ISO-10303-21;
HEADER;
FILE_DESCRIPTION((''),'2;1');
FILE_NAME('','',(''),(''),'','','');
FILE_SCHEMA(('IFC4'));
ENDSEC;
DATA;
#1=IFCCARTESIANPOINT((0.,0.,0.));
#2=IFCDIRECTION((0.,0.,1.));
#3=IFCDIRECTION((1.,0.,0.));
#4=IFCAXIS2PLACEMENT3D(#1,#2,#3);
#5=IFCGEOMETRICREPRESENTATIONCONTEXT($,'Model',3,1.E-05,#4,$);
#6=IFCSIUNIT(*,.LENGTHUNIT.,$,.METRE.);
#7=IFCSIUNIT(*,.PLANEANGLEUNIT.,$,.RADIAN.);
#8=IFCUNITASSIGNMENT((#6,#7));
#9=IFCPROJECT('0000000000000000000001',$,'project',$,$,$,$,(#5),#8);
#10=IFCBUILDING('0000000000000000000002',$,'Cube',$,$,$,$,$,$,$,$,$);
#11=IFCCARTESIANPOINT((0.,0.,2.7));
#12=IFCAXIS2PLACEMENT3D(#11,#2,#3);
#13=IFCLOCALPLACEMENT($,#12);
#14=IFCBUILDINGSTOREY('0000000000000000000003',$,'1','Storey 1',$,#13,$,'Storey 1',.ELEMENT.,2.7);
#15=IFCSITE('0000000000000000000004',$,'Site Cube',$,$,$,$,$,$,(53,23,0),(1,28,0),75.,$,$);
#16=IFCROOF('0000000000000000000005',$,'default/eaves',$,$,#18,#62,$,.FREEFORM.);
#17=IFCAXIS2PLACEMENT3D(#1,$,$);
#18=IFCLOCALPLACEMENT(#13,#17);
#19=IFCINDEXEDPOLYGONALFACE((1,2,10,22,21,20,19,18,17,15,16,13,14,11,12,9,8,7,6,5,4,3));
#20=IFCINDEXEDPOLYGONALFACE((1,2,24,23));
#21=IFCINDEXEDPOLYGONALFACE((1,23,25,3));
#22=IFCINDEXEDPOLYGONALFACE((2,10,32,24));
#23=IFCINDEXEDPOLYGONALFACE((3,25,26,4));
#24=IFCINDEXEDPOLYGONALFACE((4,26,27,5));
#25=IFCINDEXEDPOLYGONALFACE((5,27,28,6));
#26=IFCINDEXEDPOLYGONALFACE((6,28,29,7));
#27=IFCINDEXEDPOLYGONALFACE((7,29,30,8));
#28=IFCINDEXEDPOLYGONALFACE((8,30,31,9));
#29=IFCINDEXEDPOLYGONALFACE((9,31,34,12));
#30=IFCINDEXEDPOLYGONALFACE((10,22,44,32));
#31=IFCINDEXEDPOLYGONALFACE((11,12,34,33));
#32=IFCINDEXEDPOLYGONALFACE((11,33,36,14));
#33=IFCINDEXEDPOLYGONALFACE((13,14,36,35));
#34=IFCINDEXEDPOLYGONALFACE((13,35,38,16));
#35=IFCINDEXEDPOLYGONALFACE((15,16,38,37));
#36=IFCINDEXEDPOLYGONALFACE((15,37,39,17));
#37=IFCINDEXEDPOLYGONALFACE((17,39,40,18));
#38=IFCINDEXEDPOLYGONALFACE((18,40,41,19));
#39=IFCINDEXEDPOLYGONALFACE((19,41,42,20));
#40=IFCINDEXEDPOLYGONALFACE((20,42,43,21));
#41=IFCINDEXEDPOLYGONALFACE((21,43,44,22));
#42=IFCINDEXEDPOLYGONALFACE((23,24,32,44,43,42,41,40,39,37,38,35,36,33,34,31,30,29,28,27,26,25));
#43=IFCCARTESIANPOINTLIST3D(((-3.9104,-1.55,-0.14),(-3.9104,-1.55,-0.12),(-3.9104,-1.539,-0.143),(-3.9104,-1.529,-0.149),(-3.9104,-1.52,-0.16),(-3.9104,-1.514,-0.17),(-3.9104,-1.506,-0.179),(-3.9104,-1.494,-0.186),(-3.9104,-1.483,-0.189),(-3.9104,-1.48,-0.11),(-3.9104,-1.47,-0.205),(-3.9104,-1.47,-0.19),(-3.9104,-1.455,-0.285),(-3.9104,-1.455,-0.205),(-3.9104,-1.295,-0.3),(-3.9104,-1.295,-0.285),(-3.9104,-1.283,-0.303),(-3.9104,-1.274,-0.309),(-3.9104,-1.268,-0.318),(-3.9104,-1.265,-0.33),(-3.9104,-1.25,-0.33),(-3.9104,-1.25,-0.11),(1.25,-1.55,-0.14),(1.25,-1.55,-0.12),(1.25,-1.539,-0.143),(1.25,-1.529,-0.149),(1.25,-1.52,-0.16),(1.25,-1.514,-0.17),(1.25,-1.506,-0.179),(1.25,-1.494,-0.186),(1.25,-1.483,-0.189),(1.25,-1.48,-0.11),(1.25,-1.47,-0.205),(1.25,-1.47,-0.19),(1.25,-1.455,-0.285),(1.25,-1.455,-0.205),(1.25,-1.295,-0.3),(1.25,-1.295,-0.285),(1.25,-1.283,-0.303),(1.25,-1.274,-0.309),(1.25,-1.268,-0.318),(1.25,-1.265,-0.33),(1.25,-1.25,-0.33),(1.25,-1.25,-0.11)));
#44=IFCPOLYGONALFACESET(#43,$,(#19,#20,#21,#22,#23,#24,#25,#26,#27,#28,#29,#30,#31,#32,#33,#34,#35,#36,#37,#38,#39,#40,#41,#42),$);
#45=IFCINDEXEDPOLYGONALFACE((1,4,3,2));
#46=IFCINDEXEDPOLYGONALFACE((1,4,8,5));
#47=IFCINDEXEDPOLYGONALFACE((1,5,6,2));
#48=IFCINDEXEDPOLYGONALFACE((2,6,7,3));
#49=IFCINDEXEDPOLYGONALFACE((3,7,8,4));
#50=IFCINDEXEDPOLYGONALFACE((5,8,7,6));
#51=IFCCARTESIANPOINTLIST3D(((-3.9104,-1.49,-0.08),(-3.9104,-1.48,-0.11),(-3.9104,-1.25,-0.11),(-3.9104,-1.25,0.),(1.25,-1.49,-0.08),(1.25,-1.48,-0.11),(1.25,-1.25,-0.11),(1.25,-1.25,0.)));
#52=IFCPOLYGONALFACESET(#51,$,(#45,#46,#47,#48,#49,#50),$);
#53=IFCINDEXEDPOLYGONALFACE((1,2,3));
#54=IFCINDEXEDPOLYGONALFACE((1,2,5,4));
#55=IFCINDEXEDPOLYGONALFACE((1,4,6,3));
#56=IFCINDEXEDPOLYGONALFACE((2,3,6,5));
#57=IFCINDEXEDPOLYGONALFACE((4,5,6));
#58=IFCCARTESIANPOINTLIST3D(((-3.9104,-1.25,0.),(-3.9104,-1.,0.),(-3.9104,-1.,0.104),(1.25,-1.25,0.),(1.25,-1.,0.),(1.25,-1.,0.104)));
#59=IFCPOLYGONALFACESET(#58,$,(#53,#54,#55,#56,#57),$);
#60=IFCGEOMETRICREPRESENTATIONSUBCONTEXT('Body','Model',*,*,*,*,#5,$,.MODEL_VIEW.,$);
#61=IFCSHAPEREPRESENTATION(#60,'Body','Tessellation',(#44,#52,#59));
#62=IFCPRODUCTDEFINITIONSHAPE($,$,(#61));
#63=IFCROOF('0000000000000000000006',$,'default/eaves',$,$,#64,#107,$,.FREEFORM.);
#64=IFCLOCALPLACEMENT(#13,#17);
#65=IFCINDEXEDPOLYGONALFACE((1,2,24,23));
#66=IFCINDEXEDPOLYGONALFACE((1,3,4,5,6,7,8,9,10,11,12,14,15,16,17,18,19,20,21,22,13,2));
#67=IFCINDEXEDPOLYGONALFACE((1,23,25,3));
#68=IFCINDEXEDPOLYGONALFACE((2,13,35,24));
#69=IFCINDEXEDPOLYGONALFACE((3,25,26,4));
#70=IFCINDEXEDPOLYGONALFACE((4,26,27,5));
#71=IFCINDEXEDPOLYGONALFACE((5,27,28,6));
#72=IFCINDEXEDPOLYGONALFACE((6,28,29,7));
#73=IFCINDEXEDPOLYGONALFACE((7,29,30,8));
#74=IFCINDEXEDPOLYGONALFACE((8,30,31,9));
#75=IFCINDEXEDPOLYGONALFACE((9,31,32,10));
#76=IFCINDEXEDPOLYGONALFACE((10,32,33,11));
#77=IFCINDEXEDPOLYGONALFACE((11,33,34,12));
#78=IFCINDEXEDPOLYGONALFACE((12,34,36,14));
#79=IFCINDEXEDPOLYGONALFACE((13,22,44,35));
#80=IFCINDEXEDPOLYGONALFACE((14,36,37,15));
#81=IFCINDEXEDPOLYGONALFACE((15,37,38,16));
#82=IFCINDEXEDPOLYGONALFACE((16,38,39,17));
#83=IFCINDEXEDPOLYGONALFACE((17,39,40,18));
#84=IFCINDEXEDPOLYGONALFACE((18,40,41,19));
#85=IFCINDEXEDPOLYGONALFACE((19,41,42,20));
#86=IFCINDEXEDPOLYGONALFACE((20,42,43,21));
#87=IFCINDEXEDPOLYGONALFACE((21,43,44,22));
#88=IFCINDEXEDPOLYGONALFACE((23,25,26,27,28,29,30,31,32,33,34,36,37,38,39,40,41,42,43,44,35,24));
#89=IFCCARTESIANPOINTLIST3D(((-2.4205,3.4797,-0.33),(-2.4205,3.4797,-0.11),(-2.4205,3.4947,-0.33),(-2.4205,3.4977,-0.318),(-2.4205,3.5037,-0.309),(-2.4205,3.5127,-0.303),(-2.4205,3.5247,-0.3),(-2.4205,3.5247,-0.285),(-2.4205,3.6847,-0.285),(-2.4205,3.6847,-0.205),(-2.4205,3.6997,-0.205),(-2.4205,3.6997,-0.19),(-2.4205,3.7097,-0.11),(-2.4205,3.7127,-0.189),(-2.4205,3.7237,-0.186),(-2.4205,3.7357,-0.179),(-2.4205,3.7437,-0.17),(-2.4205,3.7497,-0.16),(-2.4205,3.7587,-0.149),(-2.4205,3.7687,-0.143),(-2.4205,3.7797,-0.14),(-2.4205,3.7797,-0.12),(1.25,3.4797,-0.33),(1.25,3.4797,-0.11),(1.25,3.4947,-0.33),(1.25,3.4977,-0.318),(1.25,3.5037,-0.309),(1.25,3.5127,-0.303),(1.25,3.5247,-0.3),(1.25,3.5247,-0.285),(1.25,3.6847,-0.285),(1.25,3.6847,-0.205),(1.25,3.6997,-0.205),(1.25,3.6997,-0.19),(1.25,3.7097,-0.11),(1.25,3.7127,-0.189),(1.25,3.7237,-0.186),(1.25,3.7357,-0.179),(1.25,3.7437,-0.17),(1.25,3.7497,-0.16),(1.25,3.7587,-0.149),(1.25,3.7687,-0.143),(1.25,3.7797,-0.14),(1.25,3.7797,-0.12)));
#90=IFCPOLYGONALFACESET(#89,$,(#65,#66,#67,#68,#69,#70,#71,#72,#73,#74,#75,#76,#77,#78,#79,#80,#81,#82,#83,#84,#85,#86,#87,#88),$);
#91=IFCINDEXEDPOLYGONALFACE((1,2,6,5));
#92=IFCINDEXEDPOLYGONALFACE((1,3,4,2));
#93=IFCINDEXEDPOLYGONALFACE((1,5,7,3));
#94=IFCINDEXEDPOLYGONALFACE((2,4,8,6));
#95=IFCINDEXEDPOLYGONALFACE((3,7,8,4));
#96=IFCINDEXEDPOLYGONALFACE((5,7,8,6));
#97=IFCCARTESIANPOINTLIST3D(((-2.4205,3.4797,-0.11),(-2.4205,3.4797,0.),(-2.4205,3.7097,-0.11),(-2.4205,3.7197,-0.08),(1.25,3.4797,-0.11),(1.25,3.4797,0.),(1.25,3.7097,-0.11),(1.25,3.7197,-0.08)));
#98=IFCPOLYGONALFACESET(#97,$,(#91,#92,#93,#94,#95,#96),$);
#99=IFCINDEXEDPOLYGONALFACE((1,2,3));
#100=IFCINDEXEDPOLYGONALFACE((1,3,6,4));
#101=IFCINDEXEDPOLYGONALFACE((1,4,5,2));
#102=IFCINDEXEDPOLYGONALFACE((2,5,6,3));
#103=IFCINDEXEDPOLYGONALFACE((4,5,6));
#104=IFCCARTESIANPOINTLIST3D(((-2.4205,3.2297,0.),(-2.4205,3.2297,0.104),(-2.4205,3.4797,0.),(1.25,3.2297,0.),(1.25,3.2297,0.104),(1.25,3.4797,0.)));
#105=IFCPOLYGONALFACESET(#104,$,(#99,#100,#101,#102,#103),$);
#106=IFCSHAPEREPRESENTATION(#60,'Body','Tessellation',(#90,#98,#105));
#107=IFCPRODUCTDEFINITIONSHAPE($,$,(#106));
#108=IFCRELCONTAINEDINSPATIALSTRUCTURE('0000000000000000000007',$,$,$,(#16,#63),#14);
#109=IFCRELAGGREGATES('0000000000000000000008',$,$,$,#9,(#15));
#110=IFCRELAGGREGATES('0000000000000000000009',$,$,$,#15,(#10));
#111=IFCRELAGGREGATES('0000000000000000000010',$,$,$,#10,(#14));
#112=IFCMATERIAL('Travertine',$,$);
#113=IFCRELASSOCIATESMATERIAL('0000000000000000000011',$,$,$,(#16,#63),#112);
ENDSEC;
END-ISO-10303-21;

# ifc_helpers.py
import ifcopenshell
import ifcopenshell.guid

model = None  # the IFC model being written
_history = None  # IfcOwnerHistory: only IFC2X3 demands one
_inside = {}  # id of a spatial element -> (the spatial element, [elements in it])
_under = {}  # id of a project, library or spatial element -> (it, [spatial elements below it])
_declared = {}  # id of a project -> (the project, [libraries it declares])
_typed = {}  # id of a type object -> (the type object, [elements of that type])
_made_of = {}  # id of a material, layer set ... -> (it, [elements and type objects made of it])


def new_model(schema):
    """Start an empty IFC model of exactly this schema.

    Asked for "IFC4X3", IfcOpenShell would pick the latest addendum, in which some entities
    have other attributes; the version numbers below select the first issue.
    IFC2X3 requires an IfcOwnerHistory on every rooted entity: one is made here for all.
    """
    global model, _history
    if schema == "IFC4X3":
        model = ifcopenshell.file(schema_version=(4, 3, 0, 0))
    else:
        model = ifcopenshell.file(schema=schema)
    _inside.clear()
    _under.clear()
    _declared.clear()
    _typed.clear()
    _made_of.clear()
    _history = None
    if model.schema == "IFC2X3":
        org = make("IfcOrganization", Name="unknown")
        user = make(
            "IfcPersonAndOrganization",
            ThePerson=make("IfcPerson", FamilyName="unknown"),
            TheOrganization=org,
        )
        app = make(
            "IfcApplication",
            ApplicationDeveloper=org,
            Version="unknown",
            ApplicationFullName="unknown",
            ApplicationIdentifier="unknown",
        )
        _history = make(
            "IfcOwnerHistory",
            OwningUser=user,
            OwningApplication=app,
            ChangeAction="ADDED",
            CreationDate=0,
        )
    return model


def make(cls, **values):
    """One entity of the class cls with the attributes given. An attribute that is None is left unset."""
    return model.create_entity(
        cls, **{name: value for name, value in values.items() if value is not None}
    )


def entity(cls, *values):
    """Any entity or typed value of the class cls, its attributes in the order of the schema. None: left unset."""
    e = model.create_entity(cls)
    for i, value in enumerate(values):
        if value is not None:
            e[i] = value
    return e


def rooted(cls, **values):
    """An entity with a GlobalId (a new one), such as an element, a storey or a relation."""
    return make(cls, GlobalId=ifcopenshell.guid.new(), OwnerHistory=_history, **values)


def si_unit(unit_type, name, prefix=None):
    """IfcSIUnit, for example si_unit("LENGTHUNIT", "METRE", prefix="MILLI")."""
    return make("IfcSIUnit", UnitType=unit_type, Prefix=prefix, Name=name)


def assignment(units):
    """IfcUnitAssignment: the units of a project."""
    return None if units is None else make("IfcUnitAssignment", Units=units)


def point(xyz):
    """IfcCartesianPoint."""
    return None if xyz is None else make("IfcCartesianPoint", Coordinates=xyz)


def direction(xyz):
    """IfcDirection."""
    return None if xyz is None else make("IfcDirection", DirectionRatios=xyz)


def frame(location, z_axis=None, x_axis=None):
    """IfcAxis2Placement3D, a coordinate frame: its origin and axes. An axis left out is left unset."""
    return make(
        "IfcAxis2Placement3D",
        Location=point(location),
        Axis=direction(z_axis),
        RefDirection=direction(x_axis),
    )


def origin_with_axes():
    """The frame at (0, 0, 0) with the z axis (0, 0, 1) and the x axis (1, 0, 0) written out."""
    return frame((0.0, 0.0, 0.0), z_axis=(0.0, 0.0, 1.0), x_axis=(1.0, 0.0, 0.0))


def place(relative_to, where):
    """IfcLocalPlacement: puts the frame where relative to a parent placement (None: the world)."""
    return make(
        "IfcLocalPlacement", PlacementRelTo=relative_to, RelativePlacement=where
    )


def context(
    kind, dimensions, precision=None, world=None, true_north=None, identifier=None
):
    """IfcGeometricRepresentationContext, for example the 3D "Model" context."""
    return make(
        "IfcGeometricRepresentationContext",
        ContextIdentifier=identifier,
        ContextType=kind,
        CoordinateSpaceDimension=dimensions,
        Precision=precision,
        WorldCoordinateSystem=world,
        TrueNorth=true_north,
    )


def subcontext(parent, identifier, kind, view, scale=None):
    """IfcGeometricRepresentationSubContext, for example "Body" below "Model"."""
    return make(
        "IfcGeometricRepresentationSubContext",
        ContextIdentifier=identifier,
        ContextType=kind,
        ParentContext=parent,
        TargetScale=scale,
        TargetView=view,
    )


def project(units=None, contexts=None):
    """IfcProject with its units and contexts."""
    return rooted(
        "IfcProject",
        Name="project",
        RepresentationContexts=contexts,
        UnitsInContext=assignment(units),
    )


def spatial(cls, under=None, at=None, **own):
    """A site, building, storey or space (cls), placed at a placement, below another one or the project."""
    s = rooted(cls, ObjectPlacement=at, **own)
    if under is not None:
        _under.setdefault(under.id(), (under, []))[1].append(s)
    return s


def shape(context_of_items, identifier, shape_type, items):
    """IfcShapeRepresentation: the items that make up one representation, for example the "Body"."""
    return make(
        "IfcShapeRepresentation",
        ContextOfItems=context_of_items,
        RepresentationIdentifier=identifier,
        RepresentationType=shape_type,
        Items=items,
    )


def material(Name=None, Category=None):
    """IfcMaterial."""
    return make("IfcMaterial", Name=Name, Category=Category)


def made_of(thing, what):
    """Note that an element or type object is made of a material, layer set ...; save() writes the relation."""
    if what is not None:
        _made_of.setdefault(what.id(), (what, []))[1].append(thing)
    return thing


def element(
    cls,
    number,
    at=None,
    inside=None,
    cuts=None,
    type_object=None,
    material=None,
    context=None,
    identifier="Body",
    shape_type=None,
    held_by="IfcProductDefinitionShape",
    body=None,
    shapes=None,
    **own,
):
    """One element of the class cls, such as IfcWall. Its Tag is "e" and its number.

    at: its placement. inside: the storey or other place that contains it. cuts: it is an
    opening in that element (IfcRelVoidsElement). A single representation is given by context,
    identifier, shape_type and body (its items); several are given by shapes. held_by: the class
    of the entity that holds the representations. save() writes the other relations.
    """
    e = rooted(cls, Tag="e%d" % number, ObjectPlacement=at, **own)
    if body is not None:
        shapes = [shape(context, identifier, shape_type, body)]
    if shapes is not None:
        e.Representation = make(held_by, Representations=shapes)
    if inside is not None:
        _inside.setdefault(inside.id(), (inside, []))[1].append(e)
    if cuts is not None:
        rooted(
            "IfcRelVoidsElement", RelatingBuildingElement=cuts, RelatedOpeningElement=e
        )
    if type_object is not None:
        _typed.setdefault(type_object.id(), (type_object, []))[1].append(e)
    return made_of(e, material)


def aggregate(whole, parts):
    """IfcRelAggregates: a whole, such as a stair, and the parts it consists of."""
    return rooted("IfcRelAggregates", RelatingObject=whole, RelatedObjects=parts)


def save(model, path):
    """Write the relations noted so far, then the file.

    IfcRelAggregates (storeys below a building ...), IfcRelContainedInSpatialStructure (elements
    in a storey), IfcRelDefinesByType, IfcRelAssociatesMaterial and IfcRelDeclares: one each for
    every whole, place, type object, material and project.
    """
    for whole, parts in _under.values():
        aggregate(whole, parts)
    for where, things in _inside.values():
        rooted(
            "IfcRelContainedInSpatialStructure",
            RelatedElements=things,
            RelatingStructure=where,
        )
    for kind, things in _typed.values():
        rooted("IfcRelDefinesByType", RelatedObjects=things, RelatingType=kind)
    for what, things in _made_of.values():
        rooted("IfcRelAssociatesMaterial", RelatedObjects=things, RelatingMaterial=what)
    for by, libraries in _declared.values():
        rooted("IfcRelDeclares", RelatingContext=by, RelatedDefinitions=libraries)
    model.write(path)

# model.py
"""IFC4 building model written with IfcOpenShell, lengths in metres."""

from ifc_helpers import new_model, entity, si_unit, frame, origin_with_axes, place, context, subcontext, project, spatial, material, element, save


model = new_model("IFC4")

# Units and contexts
model_context = context("Model", 3, precision=1e-05, world=origin_with_axes())
body_context = subcontext(model_context, "Body", "Model", "MODEL_VIEW")
ifc_project = project(units=[si_unit("LENGTHUNIT", "METRE"), si_unit("PLANEANGLEUNIT", "RADIAN")], contexts=[model_context])

# Site, building, storey
site = spatial("IfcSite", under=ifc_project, Name="Site Cube", RefLatitude=(53, 23, 0), RefLongitude=(1, 28, 0), RefElevation=75.0)
building = spatial("IfcBuilding", under=site, Name="Cube")
storey_placement = place(None, frame((0.0, 0.0, 2.7), z_axis=(0.0, 0.0, 1.0), x_axis=(1.0, 0.0, 0.0)))
storey = spatial("IfcBuildingStorey", under=building, at=storey_placement, Name="1", Description="Storey 1", LongName="Storey 1", CompositionType="ELEMENT", Elevation=2.7)

# Roofs
ifc_material_1 = material(Name="Travertine")
roof_1_placement = place(storey_placement, origin_with_axes())
axis2_placement3_d_1 = entity("IfcAxis2Placement3D", entity("IfcCartesianPoint", [0.0, 0.0, 0.0]))
axis2_placement3_d_2 = entity("IfcAxis2Placement3D", entity("IfcCartesianPoint", [0.0, 0.0, 0.0]))
axis2_placement3_d_3 = entity("IfcAxis2Placement3D", entity("IfcCartesianPoint", [0.0, 0.0, 0.0]))
element("IfcRoof", 1, at=roof_1_placement, inside=storey, material=ifc_material_1, Name="default/eaves", PredefinedType="FREEFORM", context=body_context, shape_type="AdvancedSweptSolid", body=[
    entity("IfcSurfaceCurveSweptAreaSolid", entity("IfcDerivedProfileDef", "AREA", None, entity("IfcArbitraryClosedProfileDef", "AREA", None, entity("IfcPolyline", [entity("IfcCartesianPoint", [-0.11, 0.25]), entity("IfcCartesianPoint", [-0.33, 0.25]), entity("IfcCartesianPoint", [-0.33, 0.265]), entity("IfcCartesianPoint", [-0.318, 0.268]), entity("IfcCartesianPoint", [-0.309, 0.274]), entity("IfcCartesianPoint", [-0.303, 0.283]), entity("IfcCartesianPoint", [-0.3, 0.295]), entity("IfcCartesianPoint", [-0.285, 0.295]), entity("IfcCartesianPoint", [-0.285, 0.455]), entity("IfcCartesianPoint", [-0.205, 0.455]), entity("IfcCartesianPoint", [-0.205, 0.47]), entity("IfcCartesianPoint", [-0.19, 0.47]), entity("IfcCartesianPoint", [-0.189, 0.483]), entity("IfcCartesianPoint", [-0.186, 0.494]), entity("IfcCartesianPoint", [-0.179, 0.506]), entity("IfcCartesianPoint", [-0.17, 0.514]), entity("IfcCartesianPoint", [-0.16, 0.52]), entity("IfcCartesianPoint", [-0.149, 0.529]), entity("IfcCartesianPoint", [-0.143, 0.539]), entity("IfcCartesianPoint", [-0.14, 0.55]), entity("IfcCartesianPoint", [-0.12, 0.55]), entity("IfcCartesianPoint", [-0.11, 0.48]), entity("IfcCartesianPoint", [-0.11, 0.25])])), entity("IfcCartesianTransformationOperator2D", None, None, entity("IfcCartesianPoint", [0.0, 0.0]), 1.0)), axis2_placement3_d_1, entity("IfcPolyline", [entity("IfcCartesianPoint", [-3.9104, -1.0]), entity("IfcCartesianPoint", [1.25, -1.0])]), 0.0, 1.0, entity("IfcPlane", axis2_placement3_d_1)),
    entity("IfcSurfaceCurveSweptAreaSolid", entity("IfcDerivedProfileDef", "AREA", None, entity("IfcArbitraryClosedProfileDef", "AREA", None, entity("IfcPolyline", [entity("IfcCartesianPoint", [-0.11, 0.25]), entity("IfcCartesianPoint", [-0.11, 0.48]), entity("IfcCartesianPoint", [-0.08, 0.49]), entity("IfcCartesianPoint", [0.0, 0.25]), entity("IfcCartesianPoint", [-0.11, 0.25])])), entity("IfcCartesianTransformationOperator2D", None, None, entity("IfcCartesianPoint", [0.0, 0.0]), 1.0)), axis2_placement3_d_2, entity("IfcPolyline", [entity("IfcCartesianPoint", [-3.9104, -1.0]), entity("IfcCartesianPoint", [1.25, -1.0])]), 0.0, 1.0, entity("IfcPlane", axis2_placement3_d_2)),
    entity("IfcSurfaceCurveSweptAreaSolid", entity("IfcDerivedProfileDef", "AREA", None, entity("IfcArbitraryClosedProfileDef", "AREA", None, entity("IfcPolyline", [entity("IfcCartesianPoint", [0.0, 0.25]), entity("IfcCartesianPoint", [0.0, 0.0]), entity("IfcCartesianPoint", [0.104, 0.0]), entity("IfcCartesianPoint", [0.0, 0.25])])), entity("IfcCartesianTransformationOperator2D", None, None, entity("IfcCartesianPoint", [0.0, 0.0]), 1.0)), axis2_placement3_d_3, entity("IfcPolyline", [entity("IfcCartesianPoint", [-3.9104, -1.0]), entity("IfcCartesianPoint", [1.25, -1.0])]), 0.0, 1.0, entity("IfcPlane", axis2_placement3_d_3)),
])
roof_2_placement = place(storey_placement, origin_with_axes())
axis2_placement3_d_4 = entity("IfcAxis2Placement3D", entity("IfcCartesianPoint", [0.0, 0.0, 0.0]))
axis2_placement3_d_5 = entity("IfcAxis2Placement3D", entity("IfcCartesianPoint", [0.0, 0.0, 0.0]))
axis2_placement3_d_6 = entity("IfcAxis2Placement3D", entity("IfcCartesianPoint", [0.0, 0.0, 0.0]))
element("IfcRoof", 2, at=roof_2_placement, inside=storey, material=ifc_material_1, Name="default/eaves", PredefinedType="FREEFORM", context=body_context, shape_type="AdvancedSweptSolid", body=[
    entity("IfcSurfaceCurveSweptAreaSolid", entity("IfcDerivedProfileDef", "AREA", None, entity("IfcArbitraryClosedProfileDef", "AREA", None, entity("IfcPolyline", [entity("IfcCartesianPoint", [-0.11, 0.25]), entity("IfcCartesianPoint", [-0.33, 0.25]), entity("IfcCartesianPoint", [-0.33, 0.265]), entity("IfcCartesianPoint", [-0.318, 0.268]), entity("IfcCartesianPoint", [-0.309, 0.274]), entity("IfcCartesianPoint", [-0.303, 0.283]), entity("IfcCartesianPoint", [-0.3, 0.295]), entity("IfcCartesianPoint", [-0.285, 0.295]), entity("IfcCartesianPoint", [-0.285, 0.455]), entity("IfcCartesianPoint", [-0.205, 0.455]), entity("IfcCartesianPoint", [-0.205, 0.47]), entity("IfcCartesianPoint", [-0.19, 0.47]), entity("IfcCartesianPoint", [-0.189, 0.483]), entity("IfcCartesianPoint", [-0.186, 0.494]), entity("IfcCartesianPoint", [-0.179, 0.506]), entity("IfcCartesianPoint", [-0.17, 0.514]), entity("IfcCartesianPoint", [-0.16, 0.52]), entity("IfcCartesianPoint", [-0.149, 0.529]), entity("IfcCartesianPoint", [-0.143, 0.539]), entity("IfcCartesianPoint", [-0.14, 0.55]), entity("IfcCartesianPoint", [-0.12, 0.55]), entity("IfcCartesianPoint", [-0.11, 0.48]), entity("IfcCartesianPoint", [-0.11, 0.25])])), entity("IfcCartesianTransformationOperator2D", None, None, entity("IfcCartesianPoint", [0.0, 0.0]), 1.0)), axis2_placement3_d_4, entity("IfcPolyline", [entity("IfcCartesianPoint", [1.25, 3.2297]), entity("IfcCartesianPoint", [-2.4205, 3.2297])]), 0.0, 1.0, entity("IfcPlane", axis2_placement3_d_4)),
    entity("IfcSurfaceCurveSweptAreaSolid", entity("IfcDerivedProfileDef", "AREA", None, entity("IfcArbitraryClosedProfileDef", "AREA", None, entity("IfcPolyline", [entity("IfcCartesianPoint", [-0.11, 0.25]), entity("IfcCartesianPoint", [-0.11, 0.48]), entity("IfcCartesianPoint", [-0.08, 0.49]), entity("IfcCartesianPoint", [0.0, 0.25]), entity("IfcCartesianPoint", [-0.11, 0.25])])), entity("IfcCartesianTransformationOperator2D", None, None, entity("IfcCartesianPoint", [0.0, 0.0]), 1.0)), axis2_placement3_d_5, entity("IfcPolyline", [entity("IfcCartesianPoint", [1.25, 3.2297]), entity("IfcCartesianPoint", [-2.4205, 3.2297])]), 0.0, 1.0, entity("IfcPlane", axis2_placement3_d_5)),
    entity("IfcSurfaceCurveSweptAreaSolid", entity("IfcDerivedProfileDef", "AREA", None, entity("IfcArbitraryClosedProfileDef", "AREA", None, entity("IfcPolyline", [entity("IfcCartesianPoint", [0.0, 0.25]), entity("IfcCartesianPoint", [0.0, 0.0]), entity("IfcCartesianPoint", [0.104, 0.0]), entity("IfcCartesianPoint", [0.0, 0.25])])), entity("IfcCartesianTransformationOperator2D", None, None, entity("IfcCartesianPoint", [0.0, 0.0]), 1.0)), axis2_placement3_d_6, entity("IfcPolyline", [entity("IfcCartesianPoint", [1.25, 3.2297]), entity("IfcCartesianPoint", [-2.4205, 3.2297])]), 0.0, 1.0, entity("IfcPlane", axis2_placement3_d_6)),
])

save(model, "model.ifc")
